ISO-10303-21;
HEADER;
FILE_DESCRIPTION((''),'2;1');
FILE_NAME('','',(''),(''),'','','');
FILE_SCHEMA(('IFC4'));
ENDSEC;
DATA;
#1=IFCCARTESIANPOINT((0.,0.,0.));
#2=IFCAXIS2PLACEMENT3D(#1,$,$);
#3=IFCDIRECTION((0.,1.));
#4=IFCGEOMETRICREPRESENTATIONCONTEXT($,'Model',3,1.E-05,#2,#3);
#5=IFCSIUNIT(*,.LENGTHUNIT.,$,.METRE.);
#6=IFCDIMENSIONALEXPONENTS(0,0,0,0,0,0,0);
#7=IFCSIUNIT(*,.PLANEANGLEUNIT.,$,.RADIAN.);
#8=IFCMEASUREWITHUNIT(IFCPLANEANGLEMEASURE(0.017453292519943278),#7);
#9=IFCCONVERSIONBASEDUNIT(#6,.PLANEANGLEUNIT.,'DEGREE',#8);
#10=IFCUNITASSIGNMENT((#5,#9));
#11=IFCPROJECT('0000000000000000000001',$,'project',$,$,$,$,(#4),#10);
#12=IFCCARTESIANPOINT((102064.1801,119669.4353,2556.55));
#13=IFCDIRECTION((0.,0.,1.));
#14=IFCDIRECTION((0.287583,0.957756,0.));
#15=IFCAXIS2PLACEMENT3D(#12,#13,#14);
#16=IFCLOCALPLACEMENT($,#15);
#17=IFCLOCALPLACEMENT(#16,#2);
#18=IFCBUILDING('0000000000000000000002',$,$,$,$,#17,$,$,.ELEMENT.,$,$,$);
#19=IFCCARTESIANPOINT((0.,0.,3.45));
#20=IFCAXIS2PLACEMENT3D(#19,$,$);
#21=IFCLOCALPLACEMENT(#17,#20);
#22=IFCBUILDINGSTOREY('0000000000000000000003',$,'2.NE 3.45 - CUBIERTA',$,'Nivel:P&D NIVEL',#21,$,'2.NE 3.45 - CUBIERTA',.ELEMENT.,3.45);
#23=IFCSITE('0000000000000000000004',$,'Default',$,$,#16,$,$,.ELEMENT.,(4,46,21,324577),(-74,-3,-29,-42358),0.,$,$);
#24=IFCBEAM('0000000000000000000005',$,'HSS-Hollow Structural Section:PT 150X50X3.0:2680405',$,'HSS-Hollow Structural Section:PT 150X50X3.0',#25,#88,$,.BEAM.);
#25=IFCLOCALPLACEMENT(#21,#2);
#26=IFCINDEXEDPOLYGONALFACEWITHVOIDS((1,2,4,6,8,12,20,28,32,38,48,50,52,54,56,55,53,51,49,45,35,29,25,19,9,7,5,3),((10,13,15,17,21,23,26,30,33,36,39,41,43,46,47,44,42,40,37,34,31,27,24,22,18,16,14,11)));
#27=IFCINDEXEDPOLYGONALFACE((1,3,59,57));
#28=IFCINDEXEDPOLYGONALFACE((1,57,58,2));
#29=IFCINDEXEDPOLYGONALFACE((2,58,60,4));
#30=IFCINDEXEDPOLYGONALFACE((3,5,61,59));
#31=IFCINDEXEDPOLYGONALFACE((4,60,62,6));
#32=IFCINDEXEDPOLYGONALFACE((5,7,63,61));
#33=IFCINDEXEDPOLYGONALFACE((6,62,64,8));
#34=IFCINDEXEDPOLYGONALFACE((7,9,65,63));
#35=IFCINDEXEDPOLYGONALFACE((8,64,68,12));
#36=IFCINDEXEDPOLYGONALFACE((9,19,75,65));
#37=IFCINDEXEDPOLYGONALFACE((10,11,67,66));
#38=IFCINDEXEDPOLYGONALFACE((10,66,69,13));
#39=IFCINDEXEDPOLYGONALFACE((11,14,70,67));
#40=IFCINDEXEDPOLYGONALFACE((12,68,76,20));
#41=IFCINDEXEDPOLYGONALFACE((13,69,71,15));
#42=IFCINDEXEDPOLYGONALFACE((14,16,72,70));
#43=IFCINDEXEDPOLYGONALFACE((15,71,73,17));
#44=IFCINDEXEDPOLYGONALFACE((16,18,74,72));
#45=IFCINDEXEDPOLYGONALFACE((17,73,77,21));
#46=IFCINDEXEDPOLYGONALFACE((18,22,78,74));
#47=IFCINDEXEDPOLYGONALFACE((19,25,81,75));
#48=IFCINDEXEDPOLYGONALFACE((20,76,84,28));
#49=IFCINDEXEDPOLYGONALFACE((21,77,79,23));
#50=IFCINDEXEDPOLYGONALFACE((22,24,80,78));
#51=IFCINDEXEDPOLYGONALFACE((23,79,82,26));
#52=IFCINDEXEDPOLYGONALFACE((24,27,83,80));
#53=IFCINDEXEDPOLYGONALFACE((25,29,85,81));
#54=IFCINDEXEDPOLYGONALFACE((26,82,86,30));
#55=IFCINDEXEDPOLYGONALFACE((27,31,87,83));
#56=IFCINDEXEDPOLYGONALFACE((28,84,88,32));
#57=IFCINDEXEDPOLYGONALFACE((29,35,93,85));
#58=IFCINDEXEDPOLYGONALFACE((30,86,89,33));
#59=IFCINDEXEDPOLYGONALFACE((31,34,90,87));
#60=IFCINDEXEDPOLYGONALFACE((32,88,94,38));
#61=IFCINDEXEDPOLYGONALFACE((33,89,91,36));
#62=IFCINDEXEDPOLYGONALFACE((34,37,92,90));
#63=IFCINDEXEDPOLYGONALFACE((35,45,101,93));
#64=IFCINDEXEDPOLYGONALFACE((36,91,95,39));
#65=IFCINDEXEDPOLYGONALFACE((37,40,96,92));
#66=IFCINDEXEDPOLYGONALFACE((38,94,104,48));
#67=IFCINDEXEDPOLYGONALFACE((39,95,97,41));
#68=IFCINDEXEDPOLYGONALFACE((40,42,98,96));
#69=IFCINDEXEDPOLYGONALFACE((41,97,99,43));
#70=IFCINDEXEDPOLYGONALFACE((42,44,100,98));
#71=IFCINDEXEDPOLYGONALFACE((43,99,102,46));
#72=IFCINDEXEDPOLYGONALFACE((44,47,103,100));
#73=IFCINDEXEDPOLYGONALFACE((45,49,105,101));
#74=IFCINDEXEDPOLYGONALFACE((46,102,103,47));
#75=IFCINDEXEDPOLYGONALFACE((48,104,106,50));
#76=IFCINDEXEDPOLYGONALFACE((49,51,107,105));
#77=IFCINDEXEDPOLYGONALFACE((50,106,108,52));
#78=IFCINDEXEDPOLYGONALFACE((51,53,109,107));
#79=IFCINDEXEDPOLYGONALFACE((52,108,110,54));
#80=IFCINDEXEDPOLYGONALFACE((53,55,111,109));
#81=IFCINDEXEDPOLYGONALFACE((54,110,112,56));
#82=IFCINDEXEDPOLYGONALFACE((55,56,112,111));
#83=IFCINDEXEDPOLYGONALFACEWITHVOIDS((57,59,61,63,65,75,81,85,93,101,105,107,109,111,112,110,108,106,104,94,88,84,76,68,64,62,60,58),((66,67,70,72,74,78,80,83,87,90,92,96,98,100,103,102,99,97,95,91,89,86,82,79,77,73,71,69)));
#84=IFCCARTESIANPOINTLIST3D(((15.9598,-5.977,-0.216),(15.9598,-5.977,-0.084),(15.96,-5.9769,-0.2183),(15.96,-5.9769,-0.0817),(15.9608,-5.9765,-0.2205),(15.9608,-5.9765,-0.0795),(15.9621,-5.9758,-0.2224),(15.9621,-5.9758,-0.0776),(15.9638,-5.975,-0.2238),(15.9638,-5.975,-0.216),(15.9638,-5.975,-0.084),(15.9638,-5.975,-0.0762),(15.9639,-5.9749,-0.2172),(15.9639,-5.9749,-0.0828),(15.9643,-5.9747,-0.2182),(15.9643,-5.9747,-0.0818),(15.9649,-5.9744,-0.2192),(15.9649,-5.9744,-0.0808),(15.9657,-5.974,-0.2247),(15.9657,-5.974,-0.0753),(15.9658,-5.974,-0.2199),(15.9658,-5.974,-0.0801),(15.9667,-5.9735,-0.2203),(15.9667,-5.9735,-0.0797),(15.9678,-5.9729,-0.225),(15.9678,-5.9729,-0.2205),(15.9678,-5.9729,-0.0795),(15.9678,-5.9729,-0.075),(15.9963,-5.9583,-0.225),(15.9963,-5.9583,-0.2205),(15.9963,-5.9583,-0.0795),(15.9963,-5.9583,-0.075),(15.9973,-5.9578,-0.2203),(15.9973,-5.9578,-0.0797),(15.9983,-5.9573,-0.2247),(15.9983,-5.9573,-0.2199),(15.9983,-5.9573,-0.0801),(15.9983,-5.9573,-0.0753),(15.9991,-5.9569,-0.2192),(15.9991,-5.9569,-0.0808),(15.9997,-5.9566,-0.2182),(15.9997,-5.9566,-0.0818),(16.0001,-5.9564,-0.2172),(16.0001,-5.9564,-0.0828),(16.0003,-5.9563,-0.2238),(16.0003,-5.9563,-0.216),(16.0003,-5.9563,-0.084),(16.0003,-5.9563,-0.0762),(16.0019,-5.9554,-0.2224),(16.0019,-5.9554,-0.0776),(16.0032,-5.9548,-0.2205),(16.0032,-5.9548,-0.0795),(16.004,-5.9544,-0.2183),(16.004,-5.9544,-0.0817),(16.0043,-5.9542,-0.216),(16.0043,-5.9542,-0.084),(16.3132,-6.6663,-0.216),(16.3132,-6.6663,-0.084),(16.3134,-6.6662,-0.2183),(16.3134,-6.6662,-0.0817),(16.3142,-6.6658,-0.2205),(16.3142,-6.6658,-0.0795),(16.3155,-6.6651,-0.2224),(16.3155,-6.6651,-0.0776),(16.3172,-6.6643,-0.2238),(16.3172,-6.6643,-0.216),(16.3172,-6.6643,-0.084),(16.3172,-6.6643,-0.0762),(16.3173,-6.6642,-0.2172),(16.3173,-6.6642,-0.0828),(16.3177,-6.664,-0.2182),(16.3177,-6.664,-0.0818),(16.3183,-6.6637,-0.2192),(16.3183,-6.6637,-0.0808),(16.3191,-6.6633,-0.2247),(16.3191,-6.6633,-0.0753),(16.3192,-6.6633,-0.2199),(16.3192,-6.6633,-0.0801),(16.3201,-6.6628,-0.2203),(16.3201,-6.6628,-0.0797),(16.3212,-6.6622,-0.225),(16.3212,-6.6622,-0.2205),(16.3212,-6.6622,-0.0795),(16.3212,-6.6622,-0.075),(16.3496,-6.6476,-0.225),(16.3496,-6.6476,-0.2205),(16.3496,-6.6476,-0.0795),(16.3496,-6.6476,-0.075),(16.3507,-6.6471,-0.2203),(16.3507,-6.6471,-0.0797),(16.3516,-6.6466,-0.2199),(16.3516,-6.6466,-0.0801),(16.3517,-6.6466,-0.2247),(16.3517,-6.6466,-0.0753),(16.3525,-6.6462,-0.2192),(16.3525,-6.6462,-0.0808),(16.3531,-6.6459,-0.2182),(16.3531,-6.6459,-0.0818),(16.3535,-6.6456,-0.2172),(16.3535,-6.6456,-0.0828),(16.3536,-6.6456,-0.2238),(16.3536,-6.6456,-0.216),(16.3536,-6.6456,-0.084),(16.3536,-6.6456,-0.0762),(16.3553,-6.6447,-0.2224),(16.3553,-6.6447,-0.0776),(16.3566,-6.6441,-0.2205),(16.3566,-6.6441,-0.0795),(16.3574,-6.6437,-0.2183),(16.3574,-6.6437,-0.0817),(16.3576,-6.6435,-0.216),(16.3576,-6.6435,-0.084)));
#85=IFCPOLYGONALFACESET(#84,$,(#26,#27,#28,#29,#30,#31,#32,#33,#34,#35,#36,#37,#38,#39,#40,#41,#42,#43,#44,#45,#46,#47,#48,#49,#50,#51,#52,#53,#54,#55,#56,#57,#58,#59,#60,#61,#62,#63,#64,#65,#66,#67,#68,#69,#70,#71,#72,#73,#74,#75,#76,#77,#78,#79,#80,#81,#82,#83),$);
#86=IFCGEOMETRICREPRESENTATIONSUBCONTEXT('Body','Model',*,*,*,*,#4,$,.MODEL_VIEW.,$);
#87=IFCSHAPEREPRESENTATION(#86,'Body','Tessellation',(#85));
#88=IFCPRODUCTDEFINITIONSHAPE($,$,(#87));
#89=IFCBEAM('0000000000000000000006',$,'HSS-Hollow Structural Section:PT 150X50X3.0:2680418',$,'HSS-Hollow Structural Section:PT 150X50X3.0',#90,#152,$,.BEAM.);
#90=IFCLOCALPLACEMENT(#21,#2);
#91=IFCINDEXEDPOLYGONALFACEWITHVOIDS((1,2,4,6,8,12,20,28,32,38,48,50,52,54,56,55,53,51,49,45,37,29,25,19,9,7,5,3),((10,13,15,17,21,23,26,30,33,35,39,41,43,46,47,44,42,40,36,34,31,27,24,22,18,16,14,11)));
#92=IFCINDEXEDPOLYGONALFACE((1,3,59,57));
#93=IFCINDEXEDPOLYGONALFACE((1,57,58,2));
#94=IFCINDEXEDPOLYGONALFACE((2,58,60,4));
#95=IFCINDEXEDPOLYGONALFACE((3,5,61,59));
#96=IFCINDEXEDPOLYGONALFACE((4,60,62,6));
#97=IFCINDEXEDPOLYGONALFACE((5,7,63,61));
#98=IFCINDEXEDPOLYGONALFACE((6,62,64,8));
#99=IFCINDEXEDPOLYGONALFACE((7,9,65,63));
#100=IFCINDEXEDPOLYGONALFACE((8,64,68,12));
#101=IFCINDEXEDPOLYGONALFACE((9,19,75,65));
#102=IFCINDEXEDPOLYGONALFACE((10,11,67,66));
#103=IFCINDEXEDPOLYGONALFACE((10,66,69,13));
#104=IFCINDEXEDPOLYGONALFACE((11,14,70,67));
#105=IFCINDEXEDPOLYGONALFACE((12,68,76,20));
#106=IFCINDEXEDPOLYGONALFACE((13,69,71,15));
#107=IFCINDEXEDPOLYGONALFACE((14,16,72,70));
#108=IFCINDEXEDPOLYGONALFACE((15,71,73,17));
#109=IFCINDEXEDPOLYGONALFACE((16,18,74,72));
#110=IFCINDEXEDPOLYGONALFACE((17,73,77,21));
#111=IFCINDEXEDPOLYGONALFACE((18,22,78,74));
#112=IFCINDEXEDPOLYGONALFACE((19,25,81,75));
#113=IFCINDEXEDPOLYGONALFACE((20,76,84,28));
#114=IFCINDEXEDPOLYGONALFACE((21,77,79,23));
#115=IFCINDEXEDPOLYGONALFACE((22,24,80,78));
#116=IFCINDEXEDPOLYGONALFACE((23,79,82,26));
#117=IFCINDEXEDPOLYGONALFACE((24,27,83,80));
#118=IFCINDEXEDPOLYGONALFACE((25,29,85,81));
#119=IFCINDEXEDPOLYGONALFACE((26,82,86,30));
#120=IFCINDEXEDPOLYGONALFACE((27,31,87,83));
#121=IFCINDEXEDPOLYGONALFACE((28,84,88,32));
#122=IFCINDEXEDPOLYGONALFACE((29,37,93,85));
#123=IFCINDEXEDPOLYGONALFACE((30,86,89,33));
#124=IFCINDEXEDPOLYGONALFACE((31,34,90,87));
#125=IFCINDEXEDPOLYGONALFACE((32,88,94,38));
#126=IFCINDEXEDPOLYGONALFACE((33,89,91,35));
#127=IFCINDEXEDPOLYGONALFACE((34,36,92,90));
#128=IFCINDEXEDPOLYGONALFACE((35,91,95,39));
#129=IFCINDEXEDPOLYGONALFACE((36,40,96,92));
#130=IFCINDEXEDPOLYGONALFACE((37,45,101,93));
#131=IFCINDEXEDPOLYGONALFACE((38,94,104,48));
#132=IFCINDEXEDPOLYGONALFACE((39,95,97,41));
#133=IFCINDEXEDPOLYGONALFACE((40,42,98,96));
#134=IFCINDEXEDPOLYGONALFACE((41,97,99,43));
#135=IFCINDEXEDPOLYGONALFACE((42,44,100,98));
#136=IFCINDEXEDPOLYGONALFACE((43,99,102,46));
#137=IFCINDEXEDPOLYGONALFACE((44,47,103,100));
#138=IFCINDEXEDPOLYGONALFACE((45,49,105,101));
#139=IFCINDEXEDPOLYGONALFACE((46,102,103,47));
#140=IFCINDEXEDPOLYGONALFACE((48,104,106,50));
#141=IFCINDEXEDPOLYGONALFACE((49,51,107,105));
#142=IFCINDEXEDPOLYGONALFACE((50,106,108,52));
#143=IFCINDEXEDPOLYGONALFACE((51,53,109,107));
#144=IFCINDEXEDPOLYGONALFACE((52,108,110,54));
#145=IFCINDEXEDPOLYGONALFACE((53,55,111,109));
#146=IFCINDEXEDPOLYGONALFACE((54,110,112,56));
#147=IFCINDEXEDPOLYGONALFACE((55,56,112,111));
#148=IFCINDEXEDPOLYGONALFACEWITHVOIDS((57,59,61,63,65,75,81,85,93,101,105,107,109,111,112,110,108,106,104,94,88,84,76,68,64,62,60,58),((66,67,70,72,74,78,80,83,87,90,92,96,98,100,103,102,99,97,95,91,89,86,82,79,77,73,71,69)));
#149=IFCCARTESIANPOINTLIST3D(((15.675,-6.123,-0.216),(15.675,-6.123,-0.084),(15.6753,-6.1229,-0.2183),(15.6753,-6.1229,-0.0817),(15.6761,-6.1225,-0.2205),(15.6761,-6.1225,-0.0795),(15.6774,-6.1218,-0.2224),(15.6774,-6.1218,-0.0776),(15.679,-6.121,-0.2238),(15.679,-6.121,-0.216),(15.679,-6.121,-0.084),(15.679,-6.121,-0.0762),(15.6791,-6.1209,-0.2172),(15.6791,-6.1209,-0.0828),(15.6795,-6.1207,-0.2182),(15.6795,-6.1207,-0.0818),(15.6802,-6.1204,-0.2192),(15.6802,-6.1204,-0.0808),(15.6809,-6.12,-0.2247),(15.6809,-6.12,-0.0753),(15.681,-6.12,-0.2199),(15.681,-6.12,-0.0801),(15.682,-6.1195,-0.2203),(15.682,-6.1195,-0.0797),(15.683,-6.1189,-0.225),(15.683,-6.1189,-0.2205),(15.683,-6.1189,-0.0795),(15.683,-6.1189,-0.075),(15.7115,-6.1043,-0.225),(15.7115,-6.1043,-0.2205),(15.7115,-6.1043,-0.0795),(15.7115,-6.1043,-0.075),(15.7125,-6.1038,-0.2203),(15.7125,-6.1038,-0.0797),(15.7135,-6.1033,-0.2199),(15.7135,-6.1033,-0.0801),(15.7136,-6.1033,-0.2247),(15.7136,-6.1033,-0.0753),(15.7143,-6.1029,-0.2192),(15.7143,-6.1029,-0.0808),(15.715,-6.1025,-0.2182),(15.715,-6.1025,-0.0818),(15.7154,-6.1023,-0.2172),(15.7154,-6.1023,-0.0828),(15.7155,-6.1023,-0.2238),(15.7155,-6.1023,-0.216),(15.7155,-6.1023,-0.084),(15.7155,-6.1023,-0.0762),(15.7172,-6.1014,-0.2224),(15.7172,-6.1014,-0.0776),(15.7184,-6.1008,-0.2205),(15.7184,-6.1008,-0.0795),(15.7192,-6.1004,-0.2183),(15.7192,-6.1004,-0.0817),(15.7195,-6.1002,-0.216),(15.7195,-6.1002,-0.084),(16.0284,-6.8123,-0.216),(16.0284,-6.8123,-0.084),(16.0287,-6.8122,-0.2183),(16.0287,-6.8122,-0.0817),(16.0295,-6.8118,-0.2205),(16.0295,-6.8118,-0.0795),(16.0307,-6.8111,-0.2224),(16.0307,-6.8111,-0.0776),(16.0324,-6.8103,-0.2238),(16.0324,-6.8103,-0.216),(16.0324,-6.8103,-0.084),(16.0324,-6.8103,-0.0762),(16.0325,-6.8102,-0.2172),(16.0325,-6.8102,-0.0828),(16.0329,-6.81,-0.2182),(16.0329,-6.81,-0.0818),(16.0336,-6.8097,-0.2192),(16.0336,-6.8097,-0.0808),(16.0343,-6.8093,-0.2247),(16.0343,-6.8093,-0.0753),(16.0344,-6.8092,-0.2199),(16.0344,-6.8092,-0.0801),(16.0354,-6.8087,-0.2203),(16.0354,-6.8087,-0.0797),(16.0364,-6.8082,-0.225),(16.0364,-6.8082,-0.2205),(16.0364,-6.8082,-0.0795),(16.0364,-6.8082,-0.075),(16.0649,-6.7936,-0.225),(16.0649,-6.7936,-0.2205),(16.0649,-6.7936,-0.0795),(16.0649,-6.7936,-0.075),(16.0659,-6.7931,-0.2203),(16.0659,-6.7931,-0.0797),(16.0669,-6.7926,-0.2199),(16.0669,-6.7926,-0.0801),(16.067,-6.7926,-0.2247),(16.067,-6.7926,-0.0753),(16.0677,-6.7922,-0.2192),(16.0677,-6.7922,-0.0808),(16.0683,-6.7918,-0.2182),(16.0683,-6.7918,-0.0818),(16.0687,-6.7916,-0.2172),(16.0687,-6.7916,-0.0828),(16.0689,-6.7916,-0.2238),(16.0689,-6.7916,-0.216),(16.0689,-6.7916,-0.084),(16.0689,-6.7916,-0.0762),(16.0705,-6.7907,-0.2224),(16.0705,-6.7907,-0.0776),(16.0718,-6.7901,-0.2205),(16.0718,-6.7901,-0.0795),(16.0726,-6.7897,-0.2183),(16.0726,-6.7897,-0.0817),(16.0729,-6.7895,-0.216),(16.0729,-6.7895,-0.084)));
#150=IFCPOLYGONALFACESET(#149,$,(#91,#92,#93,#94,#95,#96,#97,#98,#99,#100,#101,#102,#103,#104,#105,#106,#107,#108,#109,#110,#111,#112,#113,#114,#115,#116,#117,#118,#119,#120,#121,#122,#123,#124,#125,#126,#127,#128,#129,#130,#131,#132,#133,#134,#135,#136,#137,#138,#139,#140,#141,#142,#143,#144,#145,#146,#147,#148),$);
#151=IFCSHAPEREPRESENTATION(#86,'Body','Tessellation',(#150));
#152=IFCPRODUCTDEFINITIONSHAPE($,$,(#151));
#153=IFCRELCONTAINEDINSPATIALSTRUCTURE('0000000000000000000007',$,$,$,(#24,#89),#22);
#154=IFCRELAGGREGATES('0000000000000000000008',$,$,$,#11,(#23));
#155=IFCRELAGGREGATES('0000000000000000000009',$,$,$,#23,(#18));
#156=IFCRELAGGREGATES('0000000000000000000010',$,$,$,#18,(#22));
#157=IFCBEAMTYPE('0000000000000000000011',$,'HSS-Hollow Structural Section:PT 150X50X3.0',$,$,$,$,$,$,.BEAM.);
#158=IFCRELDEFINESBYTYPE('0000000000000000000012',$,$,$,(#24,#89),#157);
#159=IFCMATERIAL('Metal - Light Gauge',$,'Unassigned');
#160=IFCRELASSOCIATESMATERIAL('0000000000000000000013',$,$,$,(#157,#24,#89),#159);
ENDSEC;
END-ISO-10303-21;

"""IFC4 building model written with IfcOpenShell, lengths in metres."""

from ifc_helpers import new_model, entity, si_unit, converted_unit, direction, frame, origin, place, context, subcontext, project, spatial, line, arc, indexed_curve, outline, extrude, source, transform, mapped, material, type_object, type_shapes, element, save


model = new_model("IFC4")

# Units and contexts
model_context = context("Model", 3, precision=1e-05, world=origin(), true_north=direction((0.0, 1.0)))
body_context = subcontext(model_context, "Body", "Model", "MODEL_VIEW")
ifc_project = project(units=[si_unit("LENGTHUNIT", "METRE"), converted_unit("PLANEANGLEUNIT", "DEGREE", entity("IfcPlaneAngleMeasure", 0.017453292519943278), si_unit("PLANEANGLEUNIT", "RADIAN"), dimensions=[0, 0, 0, 0, 0, 0, 0])], contexts=[model_context])

# Site, building, storey
site_placement = place(None, frame((102064.1801, 119669.4353, 2556.55), z_axis=(0.0, 0.0, 1.0), x_axis=(0.287583, 0.957756, 0.0)))
site = spatial("IfcSite", under=ifc_project, at=site_placement, Name="Default", CompositionType="ELEMENT", RefLatitude=(4, 46, 21, 324577), RefLongitude=(-74, -3, -29, -42358), RefElevation=0.0)
building_placement = place(site_placement, origin())
building = spatial("IfcBuilding", under=site, at=building_placement, CompositionType="ELEMENT")
storey_placement = place(building_placement, frame((0.0, 0.0, 3.45)))
storey = spatial("IfcBuildingStorey", under=building, at=storey_placement, Name="2.NE 3.45 - CUBIERTA", ObjectType="Nivel:P&D NIVEL", LongName="2.NE 3.45 - CUBIERTA", CompositionType="ELEMENT", Elevation=3.45)

# Beams
ifc_material_1 = material(Name="Metal - Light Gauge", Category="Unassigned")
beam_type_1 = type_object("IfcBeamType", Name="HSS-Hollow Structural Section:PT 150X50X3.0", PredefinedType="BEAM", material=ifc_material_1)
shared_shape_1 = source(origin(), body_context, "Body", "SweptSolid", [
    extrude(outline(indexed_curve([(-0.025, -0.066), (-0.0224, -0.0724), (-0.016, -0.075), (0.016, -0.075), (0.0224, -0.0724), (0.025, -0.066), (0.025, 0.066), (0.0224, 0.0724), (0.016, 0.075), (-0.016, 0.075), (-0.0224, 0.0724), (-0.025, 0.066)], segments=[arc(1, 2, 3), line(3, 4), arc(4, 5, 6), line(6, 7), arc(7, 8, 9), line(9, 10), arc(10, 11, 12), line(12, 1)], self_intersect=False), holes=[indexed_curve([(0.016, -0.0705), (-0.016, -0.0705), (-0.0192, -0.0692), (-0.0205, -0.066), (-0.0205, 0.066), (-0.0192, 0.0692), (-0.016, 0.0705), (0.016, 0.0705), (0.0192, 0.0692), (0.0205, 0.066), (0.0205, -0.066), (0.0192, -0.0692)], segments=[line(1, 2), arc(2, 3, 4), line(4, 5), arc(5, 6, 7), line(7, 8), arc(8, 9, 10), line(10, 11), arc(11, 12, 1)], self_intersect=False)]), frame((-0.3873, 0.0, 0.0), z_axis=(1.0, 0.0, 0.0), x_axis=(0.0, -1.0, 0.0)), (0.0, 0.0, 1.0), 0.7746),
])
type_shapes(beam_type_1, [shared_shape_1])
for number, where, z_axis, x_axis, name in (
    (1, (16.1587, -6.3103, -0.15), (0.0, 0.0, 1.0), (-0.456217, 0.889869, 0.0), "HSS-Hollow Structural Section:PT 150X50X3.0:2680405"),
    (2, (15.8739, -6.4563, -0.15), (0.0, 0.0, 1.0), (-0.456217, 0.889869, 0.0), "HSS-Hollow Structural Section:PT 150X50X3.0:2680418"),
):
    element("IfcBeam", number, at=place(storey_placement, frame(where, z_axis=z_axis, x_axis=x_axis)), inside=storey, type_object=beam_type_1, material=ifc_material_1, Name=name, ObjectType="HSS-Hollow Structural Section:PT 150X50X3.0", PredefinedType="BEAM", context=body_context, shape_type="MappedRepresentation", body=[
        mapped(shared_shape_1, transform((0.0, 0.0, 0.0), scale=1.0)),
    ])

save(model, "model.ifc")
